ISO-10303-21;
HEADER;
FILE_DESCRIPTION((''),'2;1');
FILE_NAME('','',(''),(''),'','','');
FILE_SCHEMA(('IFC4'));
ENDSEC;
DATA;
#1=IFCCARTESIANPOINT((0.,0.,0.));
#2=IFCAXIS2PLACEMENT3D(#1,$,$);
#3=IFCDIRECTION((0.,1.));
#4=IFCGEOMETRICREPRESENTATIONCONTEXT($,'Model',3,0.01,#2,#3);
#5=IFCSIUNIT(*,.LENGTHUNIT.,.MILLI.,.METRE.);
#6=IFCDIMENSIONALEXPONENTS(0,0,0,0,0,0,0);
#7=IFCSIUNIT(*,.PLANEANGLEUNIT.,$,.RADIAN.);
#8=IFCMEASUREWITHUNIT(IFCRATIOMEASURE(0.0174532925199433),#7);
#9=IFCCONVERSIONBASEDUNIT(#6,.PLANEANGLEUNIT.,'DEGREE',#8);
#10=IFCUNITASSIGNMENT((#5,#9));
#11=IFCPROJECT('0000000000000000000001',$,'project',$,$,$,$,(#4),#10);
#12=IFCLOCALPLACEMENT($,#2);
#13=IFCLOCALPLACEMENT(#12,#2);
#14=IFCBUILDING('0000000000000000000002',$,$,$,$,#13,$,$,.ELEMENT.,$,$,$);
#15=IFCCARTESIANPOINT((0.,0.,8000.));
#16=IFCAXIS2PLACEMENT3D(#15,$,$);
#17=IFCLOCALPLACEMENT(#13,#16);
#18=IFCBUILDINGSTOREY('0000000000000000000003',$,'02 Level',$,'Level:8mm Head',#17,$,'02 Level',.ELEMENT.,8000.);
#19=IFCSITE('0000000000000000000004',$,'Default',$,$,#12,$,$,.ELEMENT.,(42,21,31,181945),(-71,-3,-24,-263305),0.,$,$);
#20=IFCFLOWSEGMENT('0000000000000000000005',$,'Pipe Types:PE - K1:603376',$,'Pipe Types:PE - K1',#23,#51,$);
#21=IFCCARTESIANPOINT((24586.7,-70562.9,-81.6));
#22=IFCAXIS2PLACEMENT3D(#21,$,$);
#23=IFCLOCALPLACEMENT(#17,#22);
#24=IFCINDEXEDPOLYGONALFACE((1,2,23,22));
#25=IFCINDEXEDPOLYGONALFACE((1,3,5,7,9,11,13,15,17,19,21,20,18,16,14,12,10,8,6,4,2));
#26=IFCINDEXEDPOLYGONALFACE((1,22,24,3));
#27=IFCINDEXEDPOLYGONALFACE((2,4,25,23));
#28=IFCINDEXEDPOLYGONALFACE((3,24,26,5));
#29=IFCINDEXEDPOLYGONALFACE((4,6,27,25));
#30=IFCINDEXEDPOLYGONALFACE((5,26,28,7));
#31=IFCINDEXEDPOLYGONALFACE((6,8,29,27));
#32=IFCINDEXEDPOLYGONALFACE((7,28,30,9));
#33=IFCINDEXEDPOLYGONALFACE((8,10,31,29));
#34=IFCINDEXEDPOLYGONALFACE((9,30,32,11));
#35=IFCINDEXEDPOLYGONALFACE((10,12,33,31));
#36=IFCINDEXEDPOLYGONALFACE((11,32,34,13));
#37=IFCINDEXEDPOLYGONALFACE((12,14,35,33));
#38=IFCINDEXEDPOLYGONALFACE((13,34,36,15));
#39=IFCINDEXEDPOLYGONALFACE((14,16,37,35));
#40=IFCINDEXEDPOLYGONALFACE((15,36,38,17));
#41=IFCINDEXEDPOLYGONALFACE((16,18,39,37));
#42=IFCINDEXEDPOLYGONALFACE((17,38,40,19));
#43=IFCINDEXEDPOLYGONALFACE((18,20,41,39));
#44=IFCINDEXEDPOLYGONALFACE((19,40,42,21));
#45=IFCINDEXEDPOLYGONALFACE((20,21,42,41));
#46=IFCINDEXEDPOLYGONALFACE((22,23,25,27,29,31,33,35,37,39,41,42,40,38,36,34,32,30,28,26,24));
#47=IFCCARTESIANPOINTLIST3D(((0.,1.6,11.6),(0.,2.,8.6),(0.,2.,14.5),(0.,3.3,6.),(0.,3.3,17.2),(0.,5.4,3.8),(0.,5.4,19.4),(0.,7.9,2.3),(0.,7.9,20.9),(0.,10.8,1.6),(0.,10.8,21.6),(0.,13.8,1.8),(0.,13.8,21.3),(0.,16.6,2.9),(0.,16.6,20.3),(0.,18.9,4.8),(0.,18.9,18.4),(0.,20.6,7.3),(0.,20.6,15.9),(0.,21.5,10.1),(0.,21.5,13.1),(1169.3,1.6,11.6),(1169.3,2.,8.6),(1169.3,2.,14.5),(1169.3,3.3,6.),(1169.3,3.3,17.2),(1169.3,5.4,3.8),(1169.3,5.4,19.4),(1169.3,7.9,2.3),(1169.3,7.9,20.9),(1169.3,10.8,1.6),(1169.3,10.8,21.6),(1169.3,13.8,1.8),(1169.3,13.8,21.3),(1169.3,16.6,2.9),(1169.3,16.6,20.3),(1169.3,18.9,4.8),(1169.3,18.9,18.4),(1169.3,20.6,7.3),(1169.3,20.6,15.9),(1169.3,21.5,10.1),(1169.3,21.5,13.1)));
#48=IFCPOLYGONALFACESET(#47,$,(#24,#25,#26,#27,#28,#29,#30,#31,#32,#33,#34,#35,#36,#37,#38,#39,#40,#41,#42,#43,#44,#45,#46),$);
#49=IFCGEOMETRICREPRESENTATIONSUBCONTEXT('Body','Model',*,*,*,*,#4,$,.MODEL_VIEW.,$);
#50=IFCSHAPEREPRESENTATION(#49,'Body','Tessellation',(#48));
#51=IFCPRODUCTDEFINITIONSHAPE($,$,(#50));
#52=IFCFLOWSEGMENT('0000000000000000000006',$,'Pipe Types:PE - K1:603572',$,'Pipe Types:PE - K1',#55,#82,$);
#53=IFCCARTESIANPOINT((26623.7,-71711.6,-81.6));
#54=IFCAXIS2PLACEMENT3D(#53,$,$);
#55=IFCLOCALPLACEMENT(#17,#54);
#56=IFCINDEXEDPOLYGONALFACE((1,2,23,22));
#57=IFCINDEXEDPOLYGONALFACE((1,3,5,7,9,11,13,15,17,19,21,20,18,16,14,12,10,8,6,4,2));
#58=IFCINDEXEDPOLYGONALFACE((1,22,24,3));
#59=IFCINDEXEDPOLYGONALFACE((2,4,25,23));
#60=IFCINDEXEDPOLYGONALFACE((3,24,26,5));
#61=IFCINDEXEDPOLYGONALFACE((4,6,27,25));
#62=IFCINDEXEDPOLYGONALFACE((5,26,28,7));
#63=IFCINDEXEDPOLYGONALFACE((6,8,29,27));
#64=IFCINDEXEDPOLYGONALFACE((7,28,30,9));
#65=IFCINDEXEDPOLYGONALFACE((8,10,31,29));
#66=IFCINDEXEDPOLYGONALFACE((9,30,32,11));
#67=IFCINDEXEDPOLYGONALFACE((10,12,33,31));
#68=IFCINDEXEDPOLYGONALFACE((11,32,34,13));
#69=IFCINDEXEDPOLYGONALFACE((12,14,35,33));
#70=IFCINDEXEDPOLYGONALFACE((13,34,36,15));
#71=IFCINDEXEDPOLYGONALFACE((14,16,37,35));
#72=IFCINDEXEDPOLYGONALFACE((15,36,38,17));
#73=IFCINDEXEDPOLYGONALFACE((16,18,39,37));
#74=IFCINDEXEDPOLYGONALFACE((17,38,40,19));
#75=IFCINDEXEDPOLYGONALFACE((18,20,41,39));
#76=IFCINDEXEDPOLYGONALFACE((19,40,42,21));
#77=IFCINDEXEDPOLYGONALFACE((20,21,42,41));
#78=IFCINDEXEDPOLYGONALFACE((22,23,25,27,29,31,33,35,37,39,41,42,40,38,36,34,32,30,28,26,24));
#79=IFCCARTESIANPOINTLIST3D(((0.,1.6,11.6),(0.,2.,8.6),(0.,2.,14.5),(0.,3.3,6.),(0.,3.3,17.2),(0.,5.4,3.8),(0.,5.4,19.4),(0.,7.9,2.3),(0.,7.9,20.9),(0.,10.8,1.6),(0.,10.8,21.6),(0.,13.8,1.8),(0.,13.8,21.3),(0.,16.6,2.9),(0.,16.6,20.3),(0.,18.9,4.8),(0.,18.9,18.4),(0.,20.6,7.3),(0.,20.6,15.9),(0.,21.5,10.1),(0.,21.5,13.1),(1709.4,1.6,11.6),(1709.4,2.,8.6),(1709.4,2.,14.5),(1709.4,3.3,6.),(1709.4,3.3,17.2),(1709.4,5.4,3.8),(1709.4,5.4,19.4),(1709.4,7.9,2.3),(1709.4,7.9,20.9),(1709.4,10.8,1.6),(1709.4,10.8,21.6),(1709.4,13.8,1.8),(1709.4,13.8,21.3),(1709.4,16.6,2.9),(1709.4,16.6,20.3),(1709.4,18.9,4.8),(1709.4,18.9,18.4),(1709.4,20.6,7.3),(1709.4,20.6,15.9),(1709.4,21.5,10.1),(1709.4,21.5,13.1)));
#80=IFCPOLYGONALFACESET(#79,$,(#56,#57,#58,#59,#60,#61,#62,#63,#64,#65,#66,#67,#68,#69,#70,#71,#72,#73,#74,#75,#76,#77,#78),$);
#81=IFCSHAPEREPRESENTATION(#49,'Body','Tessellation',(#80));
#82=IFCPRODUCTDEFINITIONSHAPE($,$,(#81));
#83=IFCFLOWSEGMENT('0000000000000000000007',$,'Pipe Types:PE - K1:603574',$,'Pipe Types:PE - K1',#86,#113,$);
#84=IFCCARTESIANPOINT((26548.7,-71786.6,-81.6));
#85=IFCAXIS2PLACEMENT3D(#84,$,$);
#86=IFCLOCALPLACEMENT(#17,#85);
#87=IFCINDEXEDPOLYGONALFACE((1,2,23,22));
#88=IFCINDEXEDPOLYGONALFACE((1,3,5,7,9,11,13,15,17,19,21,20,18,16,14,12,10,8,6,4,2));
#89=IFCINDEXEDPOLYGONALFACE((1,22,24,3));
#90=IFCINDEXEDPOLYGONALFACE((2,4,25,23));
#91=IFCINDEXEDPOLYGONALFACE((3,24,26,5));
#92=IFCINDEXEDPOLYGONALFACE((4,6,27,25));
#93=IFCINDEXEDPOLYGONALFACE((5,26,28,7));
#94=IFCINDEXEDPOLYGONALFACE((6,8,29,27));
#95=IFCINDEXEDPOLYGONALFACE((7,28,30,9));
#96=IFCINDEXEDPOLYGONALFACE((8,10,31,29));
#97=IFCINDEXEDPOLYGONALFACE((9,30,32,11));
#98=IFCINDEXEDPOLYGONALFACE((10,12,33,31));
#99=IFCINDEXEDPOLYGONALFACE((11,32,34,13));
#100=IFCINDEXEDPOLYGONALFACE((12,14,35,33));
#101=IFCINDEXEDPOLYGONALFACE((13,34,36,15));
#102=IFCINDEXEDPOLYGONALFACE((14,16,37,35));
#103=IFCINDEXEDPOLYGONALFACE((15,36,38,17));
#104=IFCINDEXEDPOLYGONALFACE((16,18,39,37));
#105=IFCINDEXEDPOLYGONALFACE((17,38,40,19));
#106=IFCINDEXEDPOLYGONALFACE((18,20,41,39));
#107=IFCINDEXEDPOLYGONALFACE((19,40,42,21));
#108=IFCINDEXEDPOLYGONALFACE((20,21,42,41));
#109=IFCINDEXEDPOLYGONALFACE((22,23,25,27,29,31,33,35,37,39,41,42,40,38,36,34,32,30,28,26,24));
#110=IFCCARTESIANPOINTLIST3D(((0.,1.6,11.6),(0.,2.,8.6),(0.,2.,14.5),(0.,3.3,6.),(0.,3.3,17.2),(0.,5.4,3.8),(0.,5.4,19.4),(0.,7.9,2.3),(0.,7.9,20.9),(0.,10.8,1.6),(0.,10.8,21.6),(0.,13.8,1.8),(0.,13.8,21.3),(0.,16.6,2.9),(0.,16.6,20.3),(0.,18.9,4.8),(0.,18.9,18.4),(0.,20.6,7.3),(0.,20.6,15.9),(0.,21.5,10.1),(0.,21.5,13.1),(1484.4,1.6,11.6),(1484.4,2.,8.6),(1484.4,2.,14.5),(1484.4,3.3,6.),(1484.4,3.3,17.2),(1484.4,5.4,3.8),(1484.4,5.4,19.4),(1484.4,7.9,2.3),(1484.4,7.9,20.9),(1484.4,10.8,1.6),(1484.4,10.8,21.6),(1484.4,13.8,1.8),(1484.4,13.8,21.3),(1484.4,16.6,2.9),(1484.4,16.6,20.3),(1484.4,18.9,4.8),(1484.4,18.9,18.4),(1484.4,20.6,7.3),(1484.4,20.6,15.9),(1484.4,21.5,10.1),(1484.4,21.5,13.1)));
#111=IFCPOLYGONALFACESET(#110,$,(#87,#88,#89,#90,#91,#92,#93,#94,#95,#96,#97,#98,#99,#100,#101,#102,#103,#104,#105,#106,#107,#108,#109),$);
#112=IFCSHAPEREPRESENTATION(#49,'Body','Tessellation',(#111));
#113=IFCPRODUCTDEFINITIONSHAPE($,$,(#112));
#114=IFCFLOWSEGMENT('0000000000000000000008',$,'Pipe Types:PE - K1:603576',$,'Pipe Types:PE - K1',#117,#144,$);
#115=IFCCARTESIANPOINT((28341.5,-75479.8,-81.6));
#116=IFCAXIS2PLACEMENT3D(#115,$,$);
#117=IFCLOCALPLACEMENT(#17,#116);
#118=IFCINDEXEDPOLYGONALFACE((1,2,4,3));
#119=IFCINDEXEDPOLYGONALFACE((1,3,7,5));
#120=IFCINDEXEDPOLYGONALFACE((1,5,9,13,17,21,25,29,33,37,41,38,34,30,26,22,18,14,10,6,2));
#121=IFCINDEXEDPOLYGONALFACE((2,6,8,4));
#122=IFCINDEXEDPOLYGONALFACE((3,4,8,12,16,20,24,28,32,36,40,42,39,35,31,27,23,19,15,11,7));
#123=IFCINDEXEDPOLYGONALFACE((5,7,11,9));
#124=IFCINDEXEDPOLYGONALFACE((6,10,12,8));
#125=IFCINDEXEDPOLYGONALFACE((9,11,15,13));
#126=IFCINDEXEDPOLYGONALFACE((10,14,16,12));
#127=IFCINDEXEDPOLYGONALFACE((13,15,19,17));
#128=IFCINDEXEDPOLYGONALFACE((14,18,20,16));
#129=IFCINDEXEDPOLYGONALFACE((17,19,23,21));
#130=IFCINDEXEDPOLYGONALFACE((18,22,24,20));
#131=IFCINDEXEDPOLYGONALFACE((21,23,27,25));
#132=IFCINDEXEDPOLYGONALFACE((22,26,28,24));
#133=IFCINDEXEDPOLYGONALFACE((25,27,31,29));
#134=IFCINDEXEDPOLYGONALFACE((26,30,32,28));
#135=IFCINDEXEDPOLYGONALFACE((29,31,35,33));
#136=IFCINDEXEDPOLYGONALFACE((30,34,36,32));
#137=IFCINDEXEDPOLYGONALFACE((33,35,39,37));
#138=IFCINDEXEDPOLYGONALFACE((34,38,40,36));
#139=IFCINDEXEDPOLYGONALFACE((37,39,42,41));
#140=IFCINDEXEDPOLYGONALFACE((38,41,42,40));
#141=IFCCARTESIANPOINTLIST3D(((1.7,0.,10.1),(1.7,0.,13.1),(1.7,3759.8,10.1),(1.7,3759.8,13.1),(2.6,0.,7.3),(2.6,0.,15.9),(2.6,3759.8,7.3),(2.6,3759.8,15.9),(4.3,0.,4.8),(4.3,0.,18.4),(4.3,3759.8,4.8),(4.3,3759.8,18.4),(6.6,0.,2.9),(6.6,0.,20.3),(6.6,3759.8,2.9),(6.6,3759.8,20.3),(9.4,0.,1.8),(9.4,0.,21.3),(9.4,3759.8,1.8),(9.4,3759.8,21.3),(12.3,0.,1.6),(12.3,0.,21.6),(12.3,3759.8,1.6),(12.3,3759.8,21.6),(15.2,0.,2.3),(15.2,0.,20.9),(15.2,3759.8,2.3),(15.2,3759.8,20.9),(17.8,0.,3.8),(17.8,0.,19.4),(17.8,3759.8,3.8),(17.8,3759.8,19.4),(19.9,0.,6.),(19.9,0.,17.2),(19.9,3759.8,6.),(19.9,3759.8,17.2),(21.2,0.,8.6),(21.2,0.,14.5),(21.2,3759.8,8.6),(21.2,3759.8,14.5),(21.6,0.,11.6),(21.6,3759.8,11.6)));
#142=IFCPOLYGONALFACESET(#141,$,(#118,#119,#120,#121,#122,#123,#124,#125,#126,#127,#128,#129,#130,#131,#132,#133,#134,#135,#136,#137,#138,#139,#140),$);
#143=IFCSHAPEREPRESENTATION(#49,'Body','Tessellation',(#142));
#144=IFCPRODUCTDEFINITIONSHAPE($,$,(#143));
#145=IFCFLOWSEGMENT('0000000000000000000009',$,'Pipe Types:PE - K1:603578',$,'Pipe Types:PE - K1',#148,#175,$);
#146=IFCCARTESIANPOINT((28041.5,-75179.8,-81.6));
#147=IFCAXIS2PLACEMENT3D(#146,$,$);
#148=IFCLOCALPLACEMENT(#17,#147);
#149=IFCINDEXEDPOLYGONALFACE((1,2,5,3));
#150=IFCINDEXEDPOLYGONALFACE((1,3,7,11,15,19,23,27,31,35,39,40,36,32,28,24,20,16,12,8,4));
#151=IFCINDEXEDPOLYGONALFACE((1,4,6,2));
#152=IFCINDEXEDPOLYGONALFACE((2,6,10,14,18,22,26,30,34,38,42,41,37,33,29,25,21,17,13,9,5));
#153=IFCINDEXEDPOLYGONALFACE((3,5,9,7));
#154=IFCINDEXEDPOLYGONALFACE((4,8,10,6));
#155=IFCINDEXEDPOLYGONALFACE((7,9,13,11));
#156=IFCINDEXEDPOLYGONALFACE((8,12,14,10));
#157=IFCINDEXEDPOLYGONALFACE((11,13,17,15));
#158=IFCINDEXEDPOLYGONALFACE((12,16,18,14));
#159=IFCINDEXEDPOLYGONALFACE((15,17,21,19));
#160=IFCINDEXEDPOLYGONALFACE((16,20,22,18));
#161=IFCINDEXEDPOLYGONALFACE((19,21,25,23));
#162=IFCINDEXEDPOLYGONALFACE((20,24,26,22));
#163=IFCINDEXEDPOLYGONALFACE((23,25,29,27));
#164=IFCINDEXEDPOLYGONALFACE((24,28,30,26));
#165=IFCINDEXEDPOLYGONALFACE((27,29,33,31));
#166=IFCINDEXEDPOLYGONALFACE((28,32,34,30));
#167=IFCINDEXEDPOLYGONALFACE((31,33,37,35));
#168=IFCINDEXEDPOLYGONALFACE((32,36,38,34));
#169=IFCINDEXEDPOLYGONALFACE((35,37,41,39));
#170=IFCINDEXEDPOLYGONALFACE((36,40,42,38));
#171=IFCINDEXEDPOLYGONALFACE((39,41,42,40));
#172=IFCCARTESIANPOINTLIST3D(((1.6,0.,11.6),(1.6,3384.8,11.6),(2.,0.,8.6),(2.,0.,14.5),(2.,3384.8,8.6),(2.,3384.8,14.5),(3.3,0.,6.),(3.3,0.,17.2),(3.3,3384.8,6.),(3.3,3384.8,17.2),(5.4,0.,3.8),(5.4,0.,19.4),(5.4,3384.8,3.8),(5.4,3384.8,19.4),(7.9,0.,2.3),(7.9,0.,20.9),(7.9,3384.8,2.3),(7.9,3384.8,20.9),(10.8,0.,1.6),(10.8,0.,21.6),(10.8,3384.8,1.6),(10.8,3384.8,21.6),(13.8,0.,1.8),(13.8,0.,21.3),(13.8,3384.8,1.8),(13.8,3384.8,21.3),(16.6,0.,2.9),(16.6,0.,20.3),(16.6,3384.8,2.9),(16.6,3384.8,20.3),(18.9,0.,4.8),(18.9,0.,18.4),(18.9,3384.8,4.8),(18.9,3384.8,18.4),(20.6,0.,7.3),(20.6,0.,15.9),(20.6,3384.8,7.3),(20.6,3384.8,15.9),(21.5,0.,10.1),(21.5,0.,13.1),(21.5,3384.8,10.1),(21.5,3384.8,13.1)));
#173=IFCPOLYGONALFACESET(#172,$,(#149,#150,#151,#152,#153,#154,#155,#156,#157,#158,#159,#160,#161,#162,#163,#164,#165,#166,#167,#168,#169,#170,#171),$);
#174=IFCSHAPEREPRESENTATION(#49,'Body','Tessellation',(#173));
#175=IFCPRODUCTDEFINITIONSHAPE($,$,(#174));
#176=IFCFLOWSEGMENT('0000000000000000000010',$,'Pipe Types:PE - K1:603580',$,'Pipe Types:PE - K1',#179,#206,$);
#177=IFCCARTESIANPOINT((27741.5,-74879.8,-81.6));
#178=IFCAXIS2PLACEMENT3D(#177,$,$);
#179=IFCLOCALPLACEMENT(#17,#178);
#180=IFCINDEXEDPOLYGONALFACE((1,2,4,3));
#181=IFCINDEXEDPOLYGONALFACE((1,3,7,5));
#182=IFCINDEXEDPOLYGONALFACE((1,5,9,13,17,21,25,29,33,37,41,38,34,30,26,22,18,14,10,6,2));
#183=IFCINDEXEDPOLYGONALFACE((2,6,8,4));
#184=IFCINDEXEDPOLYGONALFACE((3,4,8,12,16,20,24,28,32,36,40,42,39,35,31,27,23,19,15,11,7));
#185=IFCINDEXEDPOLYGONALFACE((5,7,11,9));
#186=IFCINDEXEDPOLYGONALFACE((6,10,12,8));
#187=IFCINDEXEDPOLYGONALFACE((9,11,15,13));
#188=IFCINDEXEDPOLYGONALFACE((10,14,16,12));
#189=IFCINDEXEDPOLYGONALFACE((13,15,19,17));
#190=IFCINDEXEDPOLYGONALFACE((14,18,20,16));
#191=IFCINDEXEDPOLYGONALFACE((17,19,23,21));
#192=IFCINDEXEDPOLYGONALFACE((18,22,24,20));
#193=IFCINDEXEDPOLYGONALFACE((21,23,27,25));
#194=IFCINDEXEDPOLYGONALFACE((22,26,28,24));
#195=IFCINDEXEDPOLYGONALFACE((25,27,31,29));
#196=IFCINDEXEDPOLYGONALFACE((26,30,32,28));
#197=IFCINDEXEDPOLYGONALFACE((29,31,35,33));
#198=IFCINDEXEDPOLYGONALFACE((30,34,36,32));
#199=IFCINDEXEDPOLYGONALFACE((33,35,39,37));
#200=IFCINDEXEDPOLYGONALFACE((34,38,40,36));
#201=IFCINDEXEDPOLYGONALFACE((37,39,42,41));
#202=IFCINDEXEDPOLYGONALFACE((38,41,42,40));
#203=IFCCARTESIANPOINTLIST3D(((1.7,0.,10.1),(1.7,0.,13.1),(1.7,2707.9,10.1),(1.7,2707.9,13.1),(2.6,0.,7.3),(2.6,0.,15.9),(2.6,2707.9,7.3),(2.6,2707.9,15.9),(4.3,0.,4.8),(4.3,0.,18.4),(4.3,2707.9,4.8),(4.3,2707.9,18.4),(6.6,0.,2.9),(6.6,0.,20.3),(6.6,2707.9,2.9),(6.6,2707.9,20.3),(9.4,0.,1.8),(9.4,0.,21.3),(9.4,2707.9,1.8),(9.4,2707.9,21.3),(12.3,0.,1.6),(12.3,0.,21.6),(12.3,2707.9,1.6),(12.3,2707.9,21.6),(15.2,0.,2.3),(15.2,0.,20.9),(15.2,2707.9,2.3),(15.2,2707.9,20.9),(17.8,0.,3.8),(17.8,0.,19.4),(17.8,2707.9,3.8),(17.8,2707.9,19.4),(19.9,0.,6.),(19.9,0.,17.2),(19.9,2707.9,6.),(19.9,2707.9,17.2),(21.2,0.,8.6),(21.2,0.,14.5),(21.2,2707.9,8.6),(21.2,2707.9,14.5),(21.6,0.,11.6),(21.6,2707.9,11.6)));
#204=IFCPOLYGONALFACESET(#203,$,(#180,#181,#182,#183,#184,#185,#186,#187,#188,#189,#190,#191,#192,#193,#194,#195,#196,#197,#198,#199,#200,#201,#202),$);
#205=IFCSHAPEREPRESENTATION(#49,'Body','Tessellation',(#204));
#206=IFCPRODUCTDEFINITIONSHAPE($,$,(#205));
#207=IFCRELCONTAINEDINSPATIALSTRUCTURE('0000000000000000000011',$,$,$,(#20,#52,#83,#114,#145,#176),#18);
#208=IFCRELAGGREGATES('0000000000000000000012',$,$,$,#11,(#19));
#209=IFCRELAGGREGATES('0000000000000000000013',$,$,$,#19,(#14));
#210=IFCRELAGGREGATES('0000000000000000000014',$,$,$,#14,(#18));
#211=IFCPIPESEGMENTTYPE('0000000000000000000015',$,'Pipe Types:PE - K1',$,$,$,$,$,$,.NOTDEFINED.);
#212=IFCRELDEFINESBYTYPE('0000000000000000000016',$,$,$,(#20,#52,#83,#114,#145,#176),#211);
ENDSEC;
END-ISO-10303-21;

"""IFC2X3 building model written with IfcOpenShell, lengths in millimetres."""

from ifc_helpers import new_model, entity, si_unit, converted_unit, direction, frame, frame_2d, origin, origin_2d_with_axis, place, context, subcontext, project, spatial, circle, extrude, type_object, element, save


model = new_model("IFC2X3")

# Units and contexts
model_context = context("Model", 3, precision=0.01, world=origin(), true_north=direction((0.0, 1.0)))
body_context = subcontext(model_context, "Body", "Model", "MODEL_VIEW")
ifc_project = project(units=[si_unit("LENGTHUNIT", "METRE", prefix="MILLI"), converted_unit("PLANEANGLEUNIT", "DEGREE", entity("IfcRatioMeasure", 0.0174532925199433), si_unit("PLANEANGLEUNIT", "RADIAN"), dimensions=[0, 0, 0, 0, 0, 0, 0])], contexts=[model_context])

# Site, building, storey
site_placement = place(None, origin())
site = spatial("IfcSite", under=ifc_project, at=site_placement, Name="Default", CompositionType="ELEMENT", RefLatitude=(42, 21, 31, 181945), RefLongitude=(-71, -3, -24, -263305), RefElevation=0.0)
building_placement = place(site_placement, origin())
building = spatial("IfcBuilding", under=site, at=building_placement, CompositionType="ELEMENT")
storey_placement = place(building_placement, frame((0.0, 0.0, 8000.0)))
storey = spatial("IfcBuildingStorey", under=building, at=storey_placement, Name="02 Level", ObjectType="Level:8mm Head", LongName="02 Level", CompositionType="ELEMENT", Elevation=8000.0)

# Flow segments
pipe_segment_type = type_object("IfcPipeSegmentType", Name="Pipe Types:PE - K1", PredefinedType="NOTDEFINED")
flow_segment_1_placement = place(storey_placement, frame((24586.7, -70562.9, -81.6)))
element("IfcFlowSegment", 1, at=flow_segment_1_placement, inside=storey, type_object=pipe_segment_type, Name="Pipe Types:PE - K1:603376", ObjectType="Pipe Types:PE - K1", context=body_context, shape_type="SweptSolid", body=[
    extrude(circle(Radius=10.0, at=origin_2d_with_axis()), frame((0.0, 11.6, 11.6), z_axis=(1.0, 0.0, 0.0), x_axis=(0.0, -1.0, 0.0)), (0.0, 0.0, 1.0), 1169.3),
])
flow_segment_2_placement = place(storey_placement, frame((26623.7, -71711.6, -81.6)))
element("IfcFlowSegment", 2, at=flow_segment_2_placement, inside=storey, type_object=pipe_segment_type, Name="Pipe Types:PE - K1:603572", ObjectType="Pipe Types:PE - K1", context=body_context, shape_type="SweptSolid", body=[
    extrude(circle(Radius=10.0, at=origin_2d_with_axis()), frame((0.0, 11.6, 11.6), z_axis=(1.0, 0.0, 0.0), x_axis=(0.0, -1.0, 0.0)), (0.0, 0.0, 1.0), 1709.4),
])
flow_segment_3_placement = place(storey_placement, frame((26548.7, -71786.6, -81.6)))
element("IfcFlowSegment", 3, at=flow_segment_3_placement, inside=storey, type_object=pipe_segment_type, Name="Pipe Types:PE - K1:603574", ObjectType="Pipe Types:PE - K1", context=body_context, shape_type="SweptSolid", body=[
    extrude(circle(Radius=10.0, at=origin_2d_with_axis()), frame((0.0, 11.6, 11.6), z_axis=(1.0, 0.0, 0.0), x_axis=(0.0, -1.0, 0.0)), (0.0, 0.0, 1.0), 1484.4),
])
flow_segment_4_placement = place(storey_placement, frame((28341.5, -75479.8, -81.6)))
element("IfcFlowSegment", 4, at=flow_segment_4_placement, inside=storey, type_object=pipe_segment_type, Name="Pipe Types:PE - K1:603576", ObjectType="Pipe Types:PE - K1", context=body_context, shape_type="SweptSolid", body=[
    extrude(circle(Radius=10.0, at=origin_2d_with_axis()), frame((11.6, 0.0, 11.6), z_axis=(0.0, 1.0, 0.0), x_axis=(1.0, 0.0, 0.0)), (0.0, 0.0, 1.0), 3759.8),
])
flow_segment_5_placement = place(storey_placement, frame((28041.5, -75179.8, -81.6)))
element("IfcFlowSegment", 5, at=flow_segment_5_placement, inside=storey, type_object=pipe_segment_type, Name="Pipe Types:PE - K1:603578", ObjectType="Pipe Types:PE - K1", context=body_context, shape_type="SweptSolid", body=[
    extrude(circle(Radius=10.0, at=frame_2d((0.0, 0.0), x_axis=(1.0, 0.0))), frame((11.6, 0.0, 11.6), z_axis=(0.0, 1.0, 0.0), x_axis=(-1.0, 0.0, 0.0)), (0.0, 0.0, 1.0), 3384.8),
])
flow_segment_6_placement = place(storey_placement, frame((27741.5, -74879.8, -81.6)))
element("IfcFlowSegment", 6, at=flow_segment_6_placement, inside=storey, type_object=pipe_segment_type, Name="Pipe Types:PE - K1:603580", ObjectType="Pipe Types:PE - K1", context=body_context, shape_type="SweptSolid", body=[
    extrude(circle(Radius=10.0, at=origin_2d_with_axis()), frame((11.6, 0.0, 11.6), z_axis=(0.0, 1.0, 0.0), x_axis=(1.0, 0.0, 0.0)), (0.0, 0.0, 1.0), 2707.9),
])

save(model, "model.ifc")
